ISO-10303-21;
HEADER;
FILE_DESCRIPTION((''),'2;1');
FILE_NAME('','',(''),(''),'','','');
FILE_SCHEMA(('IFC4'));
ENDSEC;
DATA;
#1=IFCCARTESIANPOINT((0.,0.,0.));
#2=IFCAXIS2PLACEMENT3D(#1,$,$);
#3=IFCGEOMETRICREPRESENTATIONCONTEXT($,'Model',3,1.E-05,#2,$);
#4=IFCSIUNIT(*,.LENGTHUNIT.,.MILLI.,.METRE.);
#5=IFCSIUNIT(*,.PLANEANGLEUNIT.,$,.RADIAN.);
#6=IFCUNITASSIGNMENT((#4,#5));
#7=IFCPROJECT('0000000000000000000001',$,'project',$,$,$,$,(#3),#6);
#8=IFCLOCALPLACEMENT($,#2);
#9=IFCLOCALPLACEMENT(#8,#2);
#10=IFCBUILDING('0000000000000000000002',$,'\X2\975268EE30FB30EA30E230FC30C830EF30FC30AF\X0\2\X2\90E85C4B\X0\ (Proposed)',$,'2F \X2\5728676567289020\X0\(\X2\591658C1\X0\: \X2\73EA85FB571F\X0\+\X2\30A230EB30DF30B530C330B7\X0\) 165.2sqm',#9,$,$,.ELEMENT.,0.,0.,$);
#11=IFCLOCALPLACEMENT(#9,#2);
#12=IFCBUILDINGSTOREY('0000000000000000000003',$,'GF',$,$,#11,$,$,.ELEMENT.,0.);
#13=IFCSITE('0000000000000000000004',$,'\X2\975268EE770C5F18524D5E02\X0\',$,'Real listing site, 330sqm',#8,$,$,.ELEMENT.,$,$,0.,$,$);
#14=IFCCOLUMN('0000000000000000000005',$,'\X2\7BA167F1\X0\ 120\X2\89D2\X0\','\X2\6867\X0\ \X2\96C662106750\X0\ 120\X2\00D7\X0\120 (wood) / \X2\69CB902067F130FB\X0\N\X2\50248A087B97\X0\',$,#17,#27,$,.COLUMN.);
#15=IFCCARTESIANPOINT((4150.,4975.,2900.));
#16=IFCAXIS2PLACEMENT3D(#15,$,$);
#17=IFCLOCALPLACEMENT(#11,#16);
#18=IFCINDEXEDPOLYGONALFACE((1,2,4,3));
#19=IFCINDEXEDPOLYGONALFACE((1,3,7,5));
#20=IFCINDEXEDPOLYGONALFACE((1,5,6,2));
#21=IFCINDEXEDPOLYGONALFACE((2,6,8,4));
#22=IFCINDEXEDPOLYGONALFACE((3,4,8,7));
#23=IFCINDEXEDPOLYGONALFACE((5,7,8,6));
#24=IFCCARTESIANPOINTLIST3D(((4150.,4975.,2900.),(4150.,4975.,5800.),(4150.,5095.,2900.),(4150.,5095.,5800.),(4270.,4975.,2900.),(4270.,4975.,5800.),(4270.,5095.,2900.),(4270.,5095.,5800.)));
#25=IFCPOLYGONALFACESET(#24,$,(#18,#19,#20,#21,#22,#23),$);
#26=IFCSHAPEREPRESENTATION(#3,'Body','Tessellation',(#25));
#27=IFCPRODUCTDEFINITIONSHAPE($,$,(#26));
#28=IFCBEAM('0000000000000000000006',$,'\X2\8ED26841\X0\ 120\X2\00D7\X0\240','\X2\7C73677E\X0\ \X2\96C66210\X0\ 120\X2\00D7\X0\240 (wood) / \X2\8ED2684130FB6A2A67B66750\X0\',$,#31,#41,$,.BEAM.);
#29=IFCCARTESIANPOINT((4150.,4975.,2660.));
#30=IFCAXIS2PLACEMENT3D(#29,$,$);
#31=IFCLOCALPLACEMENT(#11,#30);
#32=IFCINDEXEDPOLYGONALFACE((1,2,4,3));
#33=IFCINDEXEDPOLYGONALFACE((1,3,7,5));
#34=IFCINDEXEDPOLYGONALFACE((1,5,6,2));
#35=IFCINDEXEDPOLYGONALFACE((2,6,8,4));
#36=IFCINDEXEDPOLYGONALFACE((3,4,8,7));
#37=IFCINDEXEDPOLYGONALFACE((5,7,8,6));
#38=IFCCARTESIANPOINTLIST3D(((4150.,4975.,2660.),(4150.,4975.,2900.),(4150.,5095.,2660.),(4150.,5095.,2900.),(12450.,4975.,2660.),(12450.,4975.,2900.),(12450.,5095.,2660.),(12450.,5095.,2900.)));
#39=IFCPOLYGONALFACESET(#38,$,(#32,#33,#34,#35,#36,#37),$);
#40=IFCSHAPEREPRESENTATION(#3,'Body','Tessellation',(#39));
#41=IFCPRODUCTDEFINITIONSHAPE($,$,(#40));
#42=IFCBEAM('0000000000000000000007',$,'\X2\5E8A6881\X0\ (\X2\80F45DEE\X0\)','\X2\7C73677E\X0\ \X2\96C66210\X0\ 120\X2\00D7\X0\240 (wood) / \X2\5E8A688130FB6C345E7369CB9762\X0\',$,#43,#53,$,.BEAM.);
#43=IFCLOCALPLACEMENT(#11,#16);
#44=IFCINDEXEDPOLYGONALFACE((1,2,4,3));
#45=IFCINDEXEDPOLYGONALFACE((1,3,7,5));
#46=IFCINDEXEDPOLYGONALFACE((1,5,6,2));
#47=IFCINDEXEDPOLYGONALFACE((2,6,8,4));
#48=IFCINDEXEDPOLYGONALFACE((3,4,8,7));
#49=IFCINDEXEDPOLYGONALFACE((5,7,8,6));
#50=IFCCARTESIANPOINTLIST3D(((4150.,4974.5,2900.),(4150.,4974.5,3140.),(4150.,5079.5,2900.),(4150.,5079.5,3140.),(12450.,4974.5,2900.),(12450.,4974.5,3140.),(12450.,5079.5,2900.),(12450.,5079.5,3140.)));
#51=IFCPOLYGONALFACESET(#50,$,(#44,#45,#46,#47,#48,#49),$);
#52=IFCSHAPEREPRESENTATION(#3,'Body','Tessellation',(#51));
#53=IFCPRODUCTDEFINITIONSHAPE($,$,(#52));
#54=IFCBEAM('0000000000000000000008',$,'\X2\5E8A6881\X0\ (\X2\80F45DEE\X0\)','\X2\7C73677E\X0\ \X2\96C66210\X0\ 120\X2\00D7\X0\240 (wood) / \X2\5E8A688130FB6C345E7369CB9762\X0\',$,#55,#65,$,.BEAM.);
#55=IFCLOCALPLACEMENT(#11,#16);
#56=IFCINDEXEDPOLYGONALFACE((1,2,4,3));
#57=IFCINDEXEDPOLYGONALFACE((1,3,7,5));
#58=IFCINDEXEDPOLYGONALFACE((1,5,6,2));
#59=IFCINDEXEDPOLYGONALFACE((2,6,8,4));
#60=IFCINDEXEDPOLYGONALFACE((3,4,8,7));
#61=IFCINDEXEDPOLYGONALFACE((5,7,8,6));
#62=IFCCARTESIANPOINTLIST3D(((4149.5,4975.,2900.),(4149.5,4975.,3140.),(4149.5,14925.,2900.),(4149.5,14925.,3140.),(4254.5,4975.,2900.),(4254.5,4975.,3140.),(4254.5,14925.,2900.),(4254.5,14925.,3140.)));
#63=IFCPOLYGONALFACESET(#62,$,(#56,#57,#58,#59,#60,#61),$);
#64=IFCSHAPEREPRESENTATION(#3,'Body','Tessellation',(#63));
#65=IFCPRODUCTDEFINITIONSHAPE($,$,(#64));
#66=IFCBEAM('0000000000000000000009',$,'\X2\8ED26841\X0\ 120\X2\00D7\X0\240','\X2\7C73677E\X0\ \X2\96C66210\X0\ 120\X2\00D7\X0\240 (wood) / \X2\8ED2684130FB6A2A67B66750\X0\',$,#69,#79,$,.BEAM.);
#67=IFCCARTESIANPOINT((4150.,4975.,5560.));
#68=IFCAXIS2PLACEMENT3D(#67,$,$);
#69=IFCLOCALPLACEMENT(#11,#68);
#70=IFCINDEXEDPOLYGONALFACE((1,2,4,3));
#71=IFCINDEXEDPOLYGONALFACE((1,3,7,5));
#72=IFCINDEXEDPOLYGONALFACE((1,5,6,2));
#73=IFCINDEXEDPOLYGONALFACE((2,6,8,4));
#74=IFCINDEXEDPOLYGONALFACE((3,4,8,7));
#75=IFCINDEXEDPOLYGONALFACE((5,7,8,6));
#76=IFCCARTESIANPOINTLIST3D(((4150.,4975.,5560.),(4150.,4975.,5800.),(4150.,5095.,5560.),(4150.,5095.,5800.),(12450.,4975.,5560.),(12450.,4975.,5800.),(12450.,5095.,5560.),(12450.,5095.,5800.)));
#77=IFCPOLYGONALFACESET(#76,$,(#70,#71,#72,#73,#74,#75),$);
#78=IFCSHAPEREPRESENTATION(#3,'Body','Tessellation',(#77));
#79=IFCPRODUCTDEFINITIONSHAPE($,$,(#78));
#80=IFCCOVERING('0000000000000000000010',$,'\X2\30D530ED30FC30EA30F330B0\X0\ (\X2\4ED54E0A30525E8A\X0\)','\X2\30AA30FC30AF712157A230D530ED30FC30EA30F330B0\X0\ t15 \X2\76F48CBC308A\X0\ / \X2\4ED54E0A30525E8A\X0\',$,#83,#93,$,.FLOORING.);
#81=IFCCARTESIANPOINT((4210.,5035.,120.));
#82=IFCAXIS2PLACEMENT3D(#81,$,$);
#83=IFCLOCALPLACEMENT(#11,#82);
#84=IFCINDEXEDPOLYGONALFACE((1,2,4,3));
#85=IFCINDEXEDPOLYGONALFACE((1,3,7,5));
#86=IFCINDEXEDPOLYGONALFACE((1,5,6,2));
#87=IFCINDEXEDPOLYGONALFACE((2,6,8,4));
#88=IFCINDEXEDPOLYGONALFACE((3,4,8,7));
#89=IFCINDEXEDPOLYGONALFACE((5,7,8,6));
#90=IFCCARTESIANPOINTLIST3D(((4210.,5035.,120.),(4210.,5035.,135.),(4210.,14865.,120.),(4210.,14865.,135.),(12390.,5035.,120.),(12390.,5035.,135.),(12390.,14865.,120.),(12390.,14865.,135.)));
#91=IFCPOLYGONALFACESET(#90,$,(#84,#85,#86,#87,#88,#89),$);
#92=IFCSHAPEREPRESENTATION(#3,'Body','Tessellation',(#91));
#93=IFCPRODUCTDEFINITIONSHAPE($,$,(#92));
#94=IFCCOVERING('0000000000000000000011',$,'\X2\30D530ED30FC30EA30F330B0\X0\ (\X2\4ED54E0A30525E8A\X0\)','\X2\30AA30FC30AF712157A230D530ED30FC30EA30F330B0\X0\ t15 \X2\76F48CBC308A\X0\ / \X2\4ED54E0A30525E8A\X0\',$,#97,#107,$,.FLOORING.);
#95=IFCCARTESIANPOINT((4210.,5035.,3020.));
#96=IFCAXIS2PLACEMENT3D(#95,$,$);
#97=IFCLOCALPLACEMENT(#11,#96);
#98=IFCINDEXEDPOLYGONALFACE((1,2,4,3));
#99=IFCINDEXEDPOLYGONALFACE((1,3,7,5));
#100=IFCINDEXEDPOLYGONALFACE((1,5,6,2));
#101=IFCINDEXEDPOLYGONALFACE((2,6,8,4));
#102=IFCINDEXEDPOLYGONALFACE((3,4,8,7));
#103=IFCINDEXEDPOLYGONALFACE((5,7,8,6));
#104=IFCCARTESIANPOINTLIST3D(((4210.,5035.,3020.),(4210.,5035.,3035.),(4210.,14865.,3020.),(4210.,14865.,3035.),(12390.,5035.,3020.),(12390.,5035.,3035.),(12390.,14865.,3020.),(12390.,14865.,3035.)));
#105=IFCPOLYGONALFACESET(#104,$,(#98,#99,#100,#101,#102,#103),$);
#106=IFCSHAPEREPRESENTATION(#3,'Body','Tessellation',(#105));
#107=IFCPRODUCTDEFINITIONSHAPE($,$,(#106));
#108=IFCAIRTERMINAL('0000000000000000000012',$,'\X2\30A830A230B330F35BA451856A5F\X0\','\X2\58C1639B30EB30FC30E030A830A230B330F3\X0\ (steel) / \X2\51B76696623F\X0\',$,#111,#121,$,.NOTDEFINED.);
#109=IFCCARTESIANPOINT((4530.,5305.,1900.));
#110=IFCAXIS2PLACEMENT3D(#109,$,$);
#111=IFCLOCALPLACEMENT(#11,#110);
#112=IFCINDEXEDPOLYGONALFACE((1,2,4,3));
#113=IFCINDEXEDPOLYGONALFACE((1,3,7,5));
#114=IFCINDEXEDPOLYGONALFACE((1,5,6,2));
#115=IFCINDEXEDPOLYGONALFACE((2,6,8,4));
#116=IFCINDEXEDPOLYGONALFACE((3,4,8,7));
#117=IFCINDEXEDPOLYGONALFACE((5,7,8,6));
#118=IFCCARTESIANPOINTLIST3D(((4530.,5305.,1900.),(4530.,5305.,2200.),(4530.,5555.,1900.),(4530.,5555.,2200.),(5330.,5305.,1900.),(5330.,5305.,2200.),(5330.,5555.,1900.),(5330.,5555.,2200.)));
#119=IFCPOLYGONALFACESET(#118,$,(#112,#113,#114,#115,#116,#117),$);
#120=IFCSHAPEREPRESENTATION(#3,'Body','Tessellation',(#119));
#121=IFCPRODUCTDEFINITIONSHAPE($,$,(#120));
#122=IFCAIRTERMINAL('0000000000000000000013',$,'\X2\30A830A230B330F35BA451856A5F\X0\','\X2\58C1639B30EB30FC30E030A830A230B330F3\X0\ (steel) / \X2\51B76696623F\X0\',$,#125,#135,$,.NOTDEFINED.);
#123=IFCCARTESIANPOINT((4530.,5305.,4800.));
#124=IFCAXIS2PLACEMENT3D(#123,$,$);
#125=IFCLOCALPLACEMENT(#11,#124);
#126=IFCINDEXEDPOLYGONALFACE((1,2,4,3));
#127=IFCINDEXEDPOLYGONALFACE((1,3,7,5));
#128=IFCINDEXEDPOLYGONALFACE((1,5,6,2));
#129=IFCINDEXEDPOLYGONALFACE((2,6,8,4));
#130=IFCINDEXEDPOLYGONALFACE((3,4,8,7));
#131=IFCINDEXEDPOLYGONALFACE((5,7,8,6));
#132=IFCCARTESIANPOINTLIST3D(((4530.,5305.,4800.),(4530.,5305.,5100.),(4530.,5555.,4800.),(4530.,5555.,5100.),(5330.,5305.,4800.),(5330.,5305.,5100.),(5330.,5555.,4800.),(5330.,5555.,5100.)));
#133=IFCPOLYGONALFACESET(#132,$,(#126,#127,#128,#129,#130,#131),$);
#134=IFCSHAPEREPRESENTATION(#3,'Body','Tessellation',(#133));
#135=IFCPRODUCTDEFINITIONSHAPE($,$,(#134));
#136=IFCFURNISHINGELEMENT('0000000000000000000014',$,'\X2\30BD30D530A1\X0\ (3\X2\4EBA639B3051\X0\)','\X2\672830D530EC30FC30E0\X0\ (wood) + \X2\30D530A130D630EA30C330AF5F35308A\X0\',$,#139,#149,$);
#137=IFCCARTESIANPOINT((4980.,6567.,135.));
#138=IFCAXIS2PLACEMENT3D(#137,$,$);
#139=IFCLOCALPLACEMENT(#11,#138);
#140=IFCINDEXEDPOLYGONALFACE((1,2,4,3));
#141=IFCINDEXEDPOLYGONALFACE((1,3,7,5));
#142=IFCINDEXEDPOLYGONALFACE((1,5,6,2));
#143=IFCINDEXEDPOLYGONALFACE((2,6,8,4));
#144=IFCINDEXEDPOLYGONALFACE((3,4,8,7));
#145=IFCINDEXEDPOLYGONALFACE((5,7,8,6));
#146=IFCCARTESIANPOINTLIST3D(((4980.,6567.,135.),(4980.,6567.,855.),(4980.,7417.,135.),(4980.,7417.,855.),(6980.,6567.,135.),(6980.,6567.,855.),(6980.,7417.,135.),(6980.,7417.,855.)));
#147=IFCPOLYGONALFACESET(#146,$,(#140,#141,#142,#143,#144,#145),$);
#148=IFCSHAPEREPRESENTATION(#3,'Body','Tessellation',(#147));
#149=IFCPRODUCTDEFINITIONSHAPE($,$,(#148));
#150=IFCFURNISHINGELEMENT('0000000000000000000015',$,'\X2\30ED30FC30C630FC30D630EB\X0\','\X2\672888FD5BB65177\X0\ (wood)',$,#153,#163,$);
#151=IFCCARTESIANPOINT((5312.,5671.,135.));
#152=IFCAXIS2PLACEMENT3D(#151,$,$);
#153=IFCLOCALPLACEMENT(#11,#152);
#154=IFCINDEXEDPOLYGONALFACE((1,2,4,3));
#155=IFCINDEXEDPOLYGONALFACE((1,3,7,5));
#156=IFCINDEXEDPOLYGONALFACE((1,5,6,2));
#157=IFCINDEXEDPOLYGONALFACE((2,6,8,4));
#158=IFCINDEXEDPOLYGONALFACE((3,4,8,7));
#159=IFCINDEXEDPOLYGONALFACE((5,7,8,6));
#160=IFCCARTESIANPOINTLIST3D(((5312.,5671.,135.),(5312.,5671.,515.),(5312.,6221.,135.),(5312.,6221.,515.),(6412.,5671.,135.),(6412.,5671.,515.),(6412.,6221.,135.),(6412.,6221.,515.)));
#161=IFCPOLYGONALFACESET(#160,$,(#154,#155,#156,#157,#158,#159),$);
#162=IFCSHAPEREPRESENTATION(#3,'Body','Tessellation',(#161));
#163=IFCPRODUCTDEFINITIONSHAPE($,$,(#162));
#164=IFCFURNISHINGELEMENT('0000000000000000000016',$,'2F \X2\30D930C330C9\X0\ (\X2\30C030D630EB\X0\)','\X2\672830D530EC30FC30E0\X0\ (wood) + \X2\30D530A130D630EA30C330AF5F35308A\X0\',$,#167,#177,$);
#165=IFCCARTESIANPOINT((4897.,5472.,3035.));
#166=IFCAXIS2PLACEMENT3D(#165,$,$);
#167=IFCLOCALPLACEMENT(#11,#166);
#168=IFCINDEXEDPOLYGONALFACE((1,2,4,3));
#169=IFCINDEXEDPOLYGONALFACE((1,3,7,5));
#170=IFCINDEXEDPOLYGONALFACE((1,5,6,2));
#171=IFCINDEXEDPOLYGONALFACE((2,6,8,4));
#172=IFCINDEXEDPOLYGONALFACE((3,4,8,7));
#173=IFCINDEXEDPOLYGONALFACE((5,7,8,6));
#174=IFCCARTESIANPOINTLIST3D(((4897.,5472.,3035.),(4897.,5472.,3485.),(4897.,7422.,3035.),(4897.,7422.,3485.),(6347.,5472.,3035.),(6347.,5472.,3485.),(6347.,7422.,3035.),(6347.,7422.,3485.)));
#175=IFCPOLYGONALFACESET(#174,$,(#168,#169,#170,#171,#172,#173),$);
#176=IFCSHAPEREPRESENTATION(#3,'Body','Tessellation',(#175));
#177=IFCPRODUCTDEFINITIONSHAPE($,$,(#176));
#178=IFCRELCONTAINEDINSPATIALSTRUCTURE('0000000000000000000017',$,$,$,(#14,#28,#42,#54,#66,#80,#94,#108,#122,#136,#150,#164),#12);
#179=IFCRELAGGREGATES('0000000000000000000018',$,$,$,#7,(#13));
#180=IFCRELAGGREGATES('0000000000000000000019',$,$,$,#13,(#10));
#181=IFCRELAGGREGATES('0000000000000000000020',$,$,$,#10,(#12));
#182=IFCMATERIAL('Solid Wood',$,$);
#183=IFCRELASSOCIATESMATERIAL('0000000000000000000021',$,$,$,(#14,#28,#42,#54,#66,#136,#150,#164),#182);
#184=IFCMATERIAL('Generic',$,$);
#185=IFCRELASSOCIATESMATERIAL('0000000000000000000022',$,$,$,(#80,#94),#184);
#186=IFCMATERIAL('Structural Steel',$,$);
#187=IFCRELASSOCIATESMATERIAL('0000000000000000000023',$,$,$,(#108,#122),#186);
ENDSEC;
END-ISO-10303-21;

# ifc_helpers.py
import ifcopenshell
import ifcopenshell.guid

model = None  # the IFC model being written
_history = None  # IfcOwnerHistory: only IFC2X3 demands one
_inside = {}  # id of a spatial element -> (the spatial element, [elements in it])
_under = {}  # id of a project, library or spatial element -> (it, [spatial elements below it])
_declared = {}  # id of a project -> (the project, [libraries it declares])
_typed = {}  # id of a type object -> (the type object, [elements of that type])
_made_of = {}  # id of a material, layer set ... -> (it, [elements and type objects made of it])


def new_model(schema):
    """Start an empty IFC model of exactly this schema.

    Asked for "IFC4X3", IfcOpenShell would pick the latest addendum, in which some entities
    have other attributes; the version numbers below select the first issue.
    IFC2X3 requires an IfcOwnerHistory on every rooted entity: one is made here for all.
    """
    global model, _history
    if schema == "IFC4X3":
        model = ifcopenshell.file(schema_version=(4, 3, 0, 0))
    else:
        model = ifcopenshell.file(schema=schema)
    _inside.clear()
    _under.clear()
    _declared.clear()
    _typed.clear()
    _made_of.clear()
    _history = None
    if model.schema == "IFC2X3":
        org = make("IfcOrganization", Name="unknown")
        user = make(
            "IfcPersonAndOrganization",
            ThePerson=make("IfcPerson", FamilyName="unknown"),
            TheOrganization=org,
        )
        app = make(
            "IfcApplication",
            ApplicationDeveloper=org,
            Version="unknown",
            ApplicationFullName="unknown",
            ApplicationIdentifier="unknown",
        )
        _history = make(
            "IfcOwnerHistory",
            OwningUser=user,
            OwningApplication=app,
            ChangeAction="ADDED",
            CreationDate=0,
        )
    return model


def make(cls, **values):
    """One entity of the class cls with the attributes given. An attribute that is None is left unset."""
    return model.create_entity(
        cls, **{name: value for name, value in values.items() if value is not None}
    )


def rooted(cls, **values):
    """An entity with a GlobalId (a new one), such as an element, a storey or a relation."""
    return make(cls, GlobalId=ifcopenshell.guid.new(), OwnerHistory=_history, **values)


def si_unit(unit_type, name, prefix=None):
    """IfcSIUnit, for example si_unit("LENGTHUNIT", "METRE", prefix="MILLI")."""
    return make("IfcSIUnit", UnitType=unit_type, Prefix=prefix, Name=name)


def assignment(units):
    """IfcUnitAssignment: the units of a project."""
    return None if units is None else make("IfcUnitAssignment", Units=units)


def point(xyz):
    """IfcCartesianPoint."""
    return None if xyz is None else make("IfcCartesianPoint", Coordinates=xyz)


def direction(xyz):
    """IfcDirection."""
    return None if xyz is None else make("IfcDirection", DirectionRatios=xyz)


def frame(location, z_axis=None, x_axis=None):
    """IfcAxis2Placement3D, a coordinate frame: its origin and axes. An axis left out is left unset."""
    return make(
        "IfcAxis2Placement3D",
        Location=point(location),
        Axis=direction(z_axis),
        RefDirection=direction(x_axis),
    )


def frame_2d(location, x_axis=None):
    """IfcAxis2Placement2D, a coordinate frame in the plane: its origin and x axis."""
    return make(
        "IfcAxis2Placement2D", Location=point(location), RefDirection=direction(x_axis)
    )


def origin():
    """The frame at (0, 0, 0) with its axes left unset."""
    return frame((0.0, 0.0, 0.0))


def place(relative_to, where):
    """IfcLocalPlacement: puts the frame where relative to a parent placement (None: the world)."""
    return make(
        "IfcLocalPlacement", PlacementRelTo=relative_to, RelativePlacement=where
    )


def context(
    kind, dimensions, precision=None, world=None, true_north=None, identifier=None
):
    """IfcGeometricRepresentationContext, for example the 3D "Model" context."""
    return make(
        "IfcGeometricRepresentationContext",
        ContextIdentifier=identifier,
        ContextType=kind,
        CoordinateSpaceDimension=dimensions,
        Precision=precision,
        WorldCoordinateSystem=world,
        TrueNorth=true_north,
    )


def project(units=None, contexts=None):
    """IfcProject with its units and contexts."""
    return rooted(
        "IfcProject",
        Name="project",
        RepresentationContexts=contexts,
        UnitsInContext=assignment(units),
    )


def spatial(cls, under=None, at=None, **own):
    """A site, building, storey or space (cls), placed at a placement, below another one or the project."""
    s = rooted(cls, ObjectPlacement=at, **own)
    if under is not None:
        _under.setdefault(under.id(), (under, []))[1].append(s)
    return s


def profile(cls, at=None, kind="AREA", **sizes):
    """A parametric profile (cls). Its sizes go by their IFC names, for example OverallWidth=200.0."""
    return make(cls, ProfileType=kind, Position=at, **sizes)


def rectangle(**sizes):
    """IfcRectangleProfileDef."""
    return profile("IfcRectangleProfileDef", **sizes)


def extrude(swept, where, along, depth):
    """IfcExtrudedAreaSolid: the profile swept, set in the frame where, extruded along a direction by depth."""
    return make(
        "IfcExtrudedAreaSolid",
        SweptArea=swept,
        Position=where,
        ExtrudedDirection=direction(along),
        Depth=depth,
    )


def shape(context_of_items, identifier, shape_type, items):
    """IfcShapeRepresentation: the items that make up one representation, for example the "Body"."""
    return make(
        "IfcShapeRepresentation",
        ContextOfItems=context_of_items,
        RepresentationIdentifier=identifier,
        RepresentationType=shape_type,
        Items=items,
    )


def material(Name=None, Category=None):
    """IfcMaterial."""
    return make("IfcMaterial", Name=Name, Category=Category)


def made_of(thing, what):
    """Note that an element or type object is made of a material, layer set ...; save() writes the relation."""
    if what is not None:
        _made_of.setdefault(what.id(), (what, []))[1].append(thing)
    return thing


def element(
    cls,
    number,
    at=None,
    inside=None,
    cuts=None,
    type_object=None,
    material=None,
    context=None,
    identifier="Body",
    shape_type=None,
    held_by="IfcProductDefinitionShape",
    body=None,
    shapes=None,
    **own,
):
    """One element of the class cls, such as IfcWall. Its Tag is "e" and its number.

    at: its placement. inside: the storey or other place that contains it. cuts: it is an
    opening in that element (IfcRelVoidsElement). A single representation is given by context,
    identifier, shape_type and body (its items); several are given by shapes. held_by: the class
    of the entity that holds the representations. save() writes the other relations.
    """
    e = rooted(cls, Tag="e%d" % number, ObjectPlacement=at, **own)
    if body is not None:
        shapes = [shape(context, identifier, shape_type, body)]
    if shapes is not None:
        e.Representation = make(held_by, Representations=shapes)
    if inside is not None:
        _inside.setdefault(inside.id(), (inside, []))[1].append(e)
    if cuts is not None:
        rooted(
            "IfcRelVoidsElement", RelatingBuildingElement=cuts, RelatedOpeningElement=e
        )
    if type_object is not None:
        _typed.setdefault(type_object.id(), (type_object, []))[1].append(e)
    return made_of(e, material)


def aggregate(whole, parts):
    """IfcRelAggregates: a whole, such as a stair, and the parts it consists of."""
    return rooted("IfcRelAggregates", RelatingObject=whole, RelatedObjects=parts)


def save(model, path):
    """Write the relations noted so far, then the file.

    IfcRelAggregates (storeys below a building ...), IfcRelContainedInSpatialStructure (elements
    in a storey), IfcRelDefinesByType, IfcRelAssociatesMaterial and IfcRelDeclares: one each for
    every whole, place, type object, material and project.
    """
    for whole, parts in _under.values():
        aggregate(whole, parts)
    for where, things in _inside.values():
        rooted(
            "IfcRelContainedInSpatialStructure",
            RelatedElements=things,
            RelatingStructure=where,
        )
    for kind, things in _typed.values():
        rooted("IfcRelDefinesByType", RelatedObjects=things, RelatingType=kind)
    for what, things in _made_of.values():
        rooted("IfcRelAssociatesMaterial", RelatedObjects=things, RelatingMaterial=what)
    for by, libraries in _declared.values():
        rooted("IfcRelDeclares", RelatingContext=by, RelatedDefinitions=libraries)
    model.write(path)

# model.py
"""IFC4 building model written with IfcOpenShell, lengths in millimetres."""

from ifc_helpers import new_model, si_unit, frame, frame_2d, origin, place, context, project, spatial, rectangle, extrude, material, element, save


model = new_model("IFC4")

# Units and contexts
model_context = context("Model", 3, precision=1e-05, world=origin())
ifc_project = project(units=[si_unit("LENGTHUNIT", "METRE", prefix="MILLI"), si_unit("PLANEANGLEUNIT", "RADIAN")], contexts=[model_context])

# Site, building, storey
site_placement = place(None, origin())
site = spatial("IfcSite", under=ifc_project, at=site_placement, Name="青森県弘前市", ObjectType="Real listing site, 330sqm", CompositionType="ELEMENT", RefElevation=0.0)
building_placement = place(site_placement, origin())
building = spatial("IfcBuilding", under=site, at=building_placement, Name="青森・リモートワーク2部屋 (Proposed)", ObjectType="2F 在来木造(外壁: 珪藻土+アルミサッシ) 165.2sqm", CompositionType="ELEMENT", ElevationOfRefHeight=0.0, ElevationOfTerrain=0.0)
storey_placement = place(building_placement, origin())
storey = spatial("IfcBuildingStorey", under=building, at=storey_placement, Name="GF", CompositionType="ELEMENT", Elevation=0.0)

# Column
ifc_material_1 = material(Name="Solid Wood")
column_1_placement = place(storey_placement, frame((4150.0, 4975.0, 2900.0)))
element("IfcColumn", 1, at=column_1_placement, inside=storey, material=ifc_material_1, Name="管柱 120角", Description="桧 集成材 120×120 (wood) / 構造柱・N値計算", PredefinedType="COLUMN", context=model_context, shape_type="SweptSolid", body=[
    extrude(rectangle(XDim=120.0, YDim=120.0, at=frame_2d((60.0, 60.0))), frame((4150.0, 4975.0, 2900.0)), (0.0, 0.0, 1.0), 2900.0),
])

# Beams
beam_1_placement = place(storey_placement, frame((4150.0, 4975.0, 2660.0)))
element("IfcBeam", 2, at=beam_1_placement, inside=storey, material=ifc_material_1, Name="軒桁 120×240", Description="米松 集成 120×240 (wood) / 軒桁・横架材", PredefinedType="BEAM", context=model_context, shape_type="SweptSolid", body=[
    extrude(rectangle(XDim=8300.0, YDim=120.0, at=frame_2d((4150.0, 60.0))), frame((4150.0, 4975.0, 2660.0)), (0.0, 0.0, 1.0), 240.0),
])
beam_2_placement = place(storey_placement, frame((4150.0, 4975.0, 2900.0)))
element("IfcBeam", 3, at=beam_2_placement, inside=storey, material=ifc_material_1, Name="床梁 (胴差)", Description="米松 集成 120×240 (wood) / 床梁・水平構面", PredefinedType="BEAM", context=model_context, shape_type="SweptSolid", body=[
    extrude(rectangle(XDim=8300.0, YDim=105.0, at=frame_2d((4150.0, 52.0))), frame((4150.0, 4975.0, 2900.0)), (0.0, 0.0, 1.0), 240.0),
])
beam_3_placement = place(storey_placement, frame((4150.0, 4975.0, 2900.0)))
element("IfcBeam", 4, at=beam_3_placement, inside=storey, material=ifc_material_1, Name="床梁 (胴差)", Description="米松 集成 120×240 (wood) / 床梁・水平構面", PredefinedType="BEAM", context=model_context, shape_type="SweptSolid", body=[
    extrude(rectangle(XDim=105.0, YDim=9950.0, at=frame_2d((52.0, 4975.0))), frame((4150.0, 4975.0, 2900.0)), (0.0, 0.0, 1.0), 240.0),
])
beam_4_placement = place(storey_placement, frame((4150.0, 4975.0, 5560.0)))
element("IfcBeam", 5, at=beam_4_placement, inside=storey, material=ifc_material_1, Name="軒桁 120×240", Description="米松 集成 120×240 (wood) / 軒桁・横架材", PredefinedType="BEAM", context=model_context, shape_type="SweptSolid", body=[
    extrude(rectangle(XDim=8300.0, YDim=120.0, at=frame_2d((4150.0, 60.0))), frame((4150.0, 4975.0, 5560.0)), (0.0, 0.0, 1.0), 240.0),
])

# Coverings
ifc_material_2 = material(Name="Generic")
covering_1_placement = place(storey_placement, frame((4210.0, 5035.0, 120.0)))
element("IfcCovering", 6, at=covering_1_placement, inside=storey, material=ifc_material_2, Name="フローリング (仕上げ床)", Description="オーク無垢フローリング t15 直貼り / 仕上げ床", PredefinedType="FLOORING", context=model_context, shape_type="SweptSolid", body=[
    extrude(rectangle(XDim=8180.0, YDim=9830.0, at=frame_2d((4090.0, 4915.0))), frame((4210.0, 5035.0, 120.0)), (0.0, 0.0, 1.0), 15.0),
])
covering_2_placement = place(storey_placement, frame((4210.0, 5035.0, 3020.0)))
element("IfcCovering", 7, at=covering_2_placement, inside=storey, material=ifc_material_2, Name="フローリング (仕上げ床)", Description="オーク無垢フローリング t15 直貼り / 仕上げ床", PredefinedType="FLOORING", context=model_context, shape_type="SweptSolid", body=[
    extrude(rectangle(XDim=8180.0, YDim=9830.0, at=frame_2d((4090.0, 4915.0))), frame((4210.0, 5035.0, 3020.0)), (0.0, 0.0, 1.0), 15.0),
])

# Air terminals
ifc_material_3 = material(Name="Structural Steel")
air_terminal_1_placement = place(storey_placement, frame((4530.0, 5305.0, 1900.0)))
element("IfcAirTerminal", 8, at=air_terminal_1_placement, inside=storey, material=ifc_material_3, Name="エアコン室内機", Description="壁掛ルームエアコン (steel) / 冷暖房", PredefinedType="NOTDEFINED", context=model_context, shape_type="SweptSolid", body=[
    extrude(rectangle(XDim=800.0, YDim=250.0, at=frame_2d((400.0, 125.0))), frame((4530.0, 5305.0, 1900.0)), (0.0, 0.0, 1.0), 300.0),
])
air_terminal_2_placement = place(storey_placement, frame((4530.0, 5305.0, 4800.0)))
element("IfcAirTerminal", 9, at=air_terminal_2_placement, inside=storey, material=ifc_material_3, Name="エアコン室内機", Description="壁掛ルームエアコン (steel) / 冷暖房", PredefinedType="NOTDEFINED", context=model_context, shape_type="SweptSolid", body=[
    extrude(rectangle(XDim=800.0, YDim=250.0, at=frame_2d((400.0, 125.0))), frame((4530.0, 5305.0, 4800.0)), (0.0, 0.0, 1.0), 300.0),
])

# Furnishing elements
furnishing_1_placement = place(storey_placement, frame((4980.0, 6567.0, 135.0)))
element("IfcFurnishingElement", 10, at=furnishing_1_placement, inside=storey, material=ifc_material_1, Name="ソファ (3人掛け)", Description="木フレーム (wood) + ファブリック張り", context=model_context, shape_type="SweptSolid", body=[
    extrude(rectangle(XDim=2000.0, YDim=850.0, at=frame_2d((1000.0, 425.0))), frame((4980.0, 6567.0, 135.0)), (0.0, 0.0, 1.0), 720.0),
])
furnishing_2_placement = place(storey_placement, frame((5312.0, 5671.0, 135.0)))
element("IfcFurnishingElement", 11, at=furnishing_2_placement, inside=storey, material=ifc_material_1, Name="ローテーブル", Description="木製家具 (wood)", context=model_context, shape_type="SweptSolid", body=[
    extrude(rectangle(XDim=1100.0, YDim=550.0, at=frame_2d((550.0, 275.0))), frame((5312.0, 5671.0, 135.0)), (0.0, 0.0, 1.0), 380.0),
])
furnishing_3_placement = place(storey_placement, frame((4897.0, 5472.0, 3035.0)))
element("IfcFurnishingElement", 12, at=furnishing_3_placement, inside=storey, material=ifc_material_1, Name="2F ベッド (ダブル)", Description="木フレーム (wood) + ファブリック張り", context=model_context, shape_type="SweptSolid", body=[
    extrude(rectangle(XDim=1450.0, YDim=1950.0, at=frame_2d((725.0, 975.0))), frame((4897.0, 5472.0, 3035.0)), (0.0, 0.0, 1.0), 450.0),
])

save(model, "model.ifc")
